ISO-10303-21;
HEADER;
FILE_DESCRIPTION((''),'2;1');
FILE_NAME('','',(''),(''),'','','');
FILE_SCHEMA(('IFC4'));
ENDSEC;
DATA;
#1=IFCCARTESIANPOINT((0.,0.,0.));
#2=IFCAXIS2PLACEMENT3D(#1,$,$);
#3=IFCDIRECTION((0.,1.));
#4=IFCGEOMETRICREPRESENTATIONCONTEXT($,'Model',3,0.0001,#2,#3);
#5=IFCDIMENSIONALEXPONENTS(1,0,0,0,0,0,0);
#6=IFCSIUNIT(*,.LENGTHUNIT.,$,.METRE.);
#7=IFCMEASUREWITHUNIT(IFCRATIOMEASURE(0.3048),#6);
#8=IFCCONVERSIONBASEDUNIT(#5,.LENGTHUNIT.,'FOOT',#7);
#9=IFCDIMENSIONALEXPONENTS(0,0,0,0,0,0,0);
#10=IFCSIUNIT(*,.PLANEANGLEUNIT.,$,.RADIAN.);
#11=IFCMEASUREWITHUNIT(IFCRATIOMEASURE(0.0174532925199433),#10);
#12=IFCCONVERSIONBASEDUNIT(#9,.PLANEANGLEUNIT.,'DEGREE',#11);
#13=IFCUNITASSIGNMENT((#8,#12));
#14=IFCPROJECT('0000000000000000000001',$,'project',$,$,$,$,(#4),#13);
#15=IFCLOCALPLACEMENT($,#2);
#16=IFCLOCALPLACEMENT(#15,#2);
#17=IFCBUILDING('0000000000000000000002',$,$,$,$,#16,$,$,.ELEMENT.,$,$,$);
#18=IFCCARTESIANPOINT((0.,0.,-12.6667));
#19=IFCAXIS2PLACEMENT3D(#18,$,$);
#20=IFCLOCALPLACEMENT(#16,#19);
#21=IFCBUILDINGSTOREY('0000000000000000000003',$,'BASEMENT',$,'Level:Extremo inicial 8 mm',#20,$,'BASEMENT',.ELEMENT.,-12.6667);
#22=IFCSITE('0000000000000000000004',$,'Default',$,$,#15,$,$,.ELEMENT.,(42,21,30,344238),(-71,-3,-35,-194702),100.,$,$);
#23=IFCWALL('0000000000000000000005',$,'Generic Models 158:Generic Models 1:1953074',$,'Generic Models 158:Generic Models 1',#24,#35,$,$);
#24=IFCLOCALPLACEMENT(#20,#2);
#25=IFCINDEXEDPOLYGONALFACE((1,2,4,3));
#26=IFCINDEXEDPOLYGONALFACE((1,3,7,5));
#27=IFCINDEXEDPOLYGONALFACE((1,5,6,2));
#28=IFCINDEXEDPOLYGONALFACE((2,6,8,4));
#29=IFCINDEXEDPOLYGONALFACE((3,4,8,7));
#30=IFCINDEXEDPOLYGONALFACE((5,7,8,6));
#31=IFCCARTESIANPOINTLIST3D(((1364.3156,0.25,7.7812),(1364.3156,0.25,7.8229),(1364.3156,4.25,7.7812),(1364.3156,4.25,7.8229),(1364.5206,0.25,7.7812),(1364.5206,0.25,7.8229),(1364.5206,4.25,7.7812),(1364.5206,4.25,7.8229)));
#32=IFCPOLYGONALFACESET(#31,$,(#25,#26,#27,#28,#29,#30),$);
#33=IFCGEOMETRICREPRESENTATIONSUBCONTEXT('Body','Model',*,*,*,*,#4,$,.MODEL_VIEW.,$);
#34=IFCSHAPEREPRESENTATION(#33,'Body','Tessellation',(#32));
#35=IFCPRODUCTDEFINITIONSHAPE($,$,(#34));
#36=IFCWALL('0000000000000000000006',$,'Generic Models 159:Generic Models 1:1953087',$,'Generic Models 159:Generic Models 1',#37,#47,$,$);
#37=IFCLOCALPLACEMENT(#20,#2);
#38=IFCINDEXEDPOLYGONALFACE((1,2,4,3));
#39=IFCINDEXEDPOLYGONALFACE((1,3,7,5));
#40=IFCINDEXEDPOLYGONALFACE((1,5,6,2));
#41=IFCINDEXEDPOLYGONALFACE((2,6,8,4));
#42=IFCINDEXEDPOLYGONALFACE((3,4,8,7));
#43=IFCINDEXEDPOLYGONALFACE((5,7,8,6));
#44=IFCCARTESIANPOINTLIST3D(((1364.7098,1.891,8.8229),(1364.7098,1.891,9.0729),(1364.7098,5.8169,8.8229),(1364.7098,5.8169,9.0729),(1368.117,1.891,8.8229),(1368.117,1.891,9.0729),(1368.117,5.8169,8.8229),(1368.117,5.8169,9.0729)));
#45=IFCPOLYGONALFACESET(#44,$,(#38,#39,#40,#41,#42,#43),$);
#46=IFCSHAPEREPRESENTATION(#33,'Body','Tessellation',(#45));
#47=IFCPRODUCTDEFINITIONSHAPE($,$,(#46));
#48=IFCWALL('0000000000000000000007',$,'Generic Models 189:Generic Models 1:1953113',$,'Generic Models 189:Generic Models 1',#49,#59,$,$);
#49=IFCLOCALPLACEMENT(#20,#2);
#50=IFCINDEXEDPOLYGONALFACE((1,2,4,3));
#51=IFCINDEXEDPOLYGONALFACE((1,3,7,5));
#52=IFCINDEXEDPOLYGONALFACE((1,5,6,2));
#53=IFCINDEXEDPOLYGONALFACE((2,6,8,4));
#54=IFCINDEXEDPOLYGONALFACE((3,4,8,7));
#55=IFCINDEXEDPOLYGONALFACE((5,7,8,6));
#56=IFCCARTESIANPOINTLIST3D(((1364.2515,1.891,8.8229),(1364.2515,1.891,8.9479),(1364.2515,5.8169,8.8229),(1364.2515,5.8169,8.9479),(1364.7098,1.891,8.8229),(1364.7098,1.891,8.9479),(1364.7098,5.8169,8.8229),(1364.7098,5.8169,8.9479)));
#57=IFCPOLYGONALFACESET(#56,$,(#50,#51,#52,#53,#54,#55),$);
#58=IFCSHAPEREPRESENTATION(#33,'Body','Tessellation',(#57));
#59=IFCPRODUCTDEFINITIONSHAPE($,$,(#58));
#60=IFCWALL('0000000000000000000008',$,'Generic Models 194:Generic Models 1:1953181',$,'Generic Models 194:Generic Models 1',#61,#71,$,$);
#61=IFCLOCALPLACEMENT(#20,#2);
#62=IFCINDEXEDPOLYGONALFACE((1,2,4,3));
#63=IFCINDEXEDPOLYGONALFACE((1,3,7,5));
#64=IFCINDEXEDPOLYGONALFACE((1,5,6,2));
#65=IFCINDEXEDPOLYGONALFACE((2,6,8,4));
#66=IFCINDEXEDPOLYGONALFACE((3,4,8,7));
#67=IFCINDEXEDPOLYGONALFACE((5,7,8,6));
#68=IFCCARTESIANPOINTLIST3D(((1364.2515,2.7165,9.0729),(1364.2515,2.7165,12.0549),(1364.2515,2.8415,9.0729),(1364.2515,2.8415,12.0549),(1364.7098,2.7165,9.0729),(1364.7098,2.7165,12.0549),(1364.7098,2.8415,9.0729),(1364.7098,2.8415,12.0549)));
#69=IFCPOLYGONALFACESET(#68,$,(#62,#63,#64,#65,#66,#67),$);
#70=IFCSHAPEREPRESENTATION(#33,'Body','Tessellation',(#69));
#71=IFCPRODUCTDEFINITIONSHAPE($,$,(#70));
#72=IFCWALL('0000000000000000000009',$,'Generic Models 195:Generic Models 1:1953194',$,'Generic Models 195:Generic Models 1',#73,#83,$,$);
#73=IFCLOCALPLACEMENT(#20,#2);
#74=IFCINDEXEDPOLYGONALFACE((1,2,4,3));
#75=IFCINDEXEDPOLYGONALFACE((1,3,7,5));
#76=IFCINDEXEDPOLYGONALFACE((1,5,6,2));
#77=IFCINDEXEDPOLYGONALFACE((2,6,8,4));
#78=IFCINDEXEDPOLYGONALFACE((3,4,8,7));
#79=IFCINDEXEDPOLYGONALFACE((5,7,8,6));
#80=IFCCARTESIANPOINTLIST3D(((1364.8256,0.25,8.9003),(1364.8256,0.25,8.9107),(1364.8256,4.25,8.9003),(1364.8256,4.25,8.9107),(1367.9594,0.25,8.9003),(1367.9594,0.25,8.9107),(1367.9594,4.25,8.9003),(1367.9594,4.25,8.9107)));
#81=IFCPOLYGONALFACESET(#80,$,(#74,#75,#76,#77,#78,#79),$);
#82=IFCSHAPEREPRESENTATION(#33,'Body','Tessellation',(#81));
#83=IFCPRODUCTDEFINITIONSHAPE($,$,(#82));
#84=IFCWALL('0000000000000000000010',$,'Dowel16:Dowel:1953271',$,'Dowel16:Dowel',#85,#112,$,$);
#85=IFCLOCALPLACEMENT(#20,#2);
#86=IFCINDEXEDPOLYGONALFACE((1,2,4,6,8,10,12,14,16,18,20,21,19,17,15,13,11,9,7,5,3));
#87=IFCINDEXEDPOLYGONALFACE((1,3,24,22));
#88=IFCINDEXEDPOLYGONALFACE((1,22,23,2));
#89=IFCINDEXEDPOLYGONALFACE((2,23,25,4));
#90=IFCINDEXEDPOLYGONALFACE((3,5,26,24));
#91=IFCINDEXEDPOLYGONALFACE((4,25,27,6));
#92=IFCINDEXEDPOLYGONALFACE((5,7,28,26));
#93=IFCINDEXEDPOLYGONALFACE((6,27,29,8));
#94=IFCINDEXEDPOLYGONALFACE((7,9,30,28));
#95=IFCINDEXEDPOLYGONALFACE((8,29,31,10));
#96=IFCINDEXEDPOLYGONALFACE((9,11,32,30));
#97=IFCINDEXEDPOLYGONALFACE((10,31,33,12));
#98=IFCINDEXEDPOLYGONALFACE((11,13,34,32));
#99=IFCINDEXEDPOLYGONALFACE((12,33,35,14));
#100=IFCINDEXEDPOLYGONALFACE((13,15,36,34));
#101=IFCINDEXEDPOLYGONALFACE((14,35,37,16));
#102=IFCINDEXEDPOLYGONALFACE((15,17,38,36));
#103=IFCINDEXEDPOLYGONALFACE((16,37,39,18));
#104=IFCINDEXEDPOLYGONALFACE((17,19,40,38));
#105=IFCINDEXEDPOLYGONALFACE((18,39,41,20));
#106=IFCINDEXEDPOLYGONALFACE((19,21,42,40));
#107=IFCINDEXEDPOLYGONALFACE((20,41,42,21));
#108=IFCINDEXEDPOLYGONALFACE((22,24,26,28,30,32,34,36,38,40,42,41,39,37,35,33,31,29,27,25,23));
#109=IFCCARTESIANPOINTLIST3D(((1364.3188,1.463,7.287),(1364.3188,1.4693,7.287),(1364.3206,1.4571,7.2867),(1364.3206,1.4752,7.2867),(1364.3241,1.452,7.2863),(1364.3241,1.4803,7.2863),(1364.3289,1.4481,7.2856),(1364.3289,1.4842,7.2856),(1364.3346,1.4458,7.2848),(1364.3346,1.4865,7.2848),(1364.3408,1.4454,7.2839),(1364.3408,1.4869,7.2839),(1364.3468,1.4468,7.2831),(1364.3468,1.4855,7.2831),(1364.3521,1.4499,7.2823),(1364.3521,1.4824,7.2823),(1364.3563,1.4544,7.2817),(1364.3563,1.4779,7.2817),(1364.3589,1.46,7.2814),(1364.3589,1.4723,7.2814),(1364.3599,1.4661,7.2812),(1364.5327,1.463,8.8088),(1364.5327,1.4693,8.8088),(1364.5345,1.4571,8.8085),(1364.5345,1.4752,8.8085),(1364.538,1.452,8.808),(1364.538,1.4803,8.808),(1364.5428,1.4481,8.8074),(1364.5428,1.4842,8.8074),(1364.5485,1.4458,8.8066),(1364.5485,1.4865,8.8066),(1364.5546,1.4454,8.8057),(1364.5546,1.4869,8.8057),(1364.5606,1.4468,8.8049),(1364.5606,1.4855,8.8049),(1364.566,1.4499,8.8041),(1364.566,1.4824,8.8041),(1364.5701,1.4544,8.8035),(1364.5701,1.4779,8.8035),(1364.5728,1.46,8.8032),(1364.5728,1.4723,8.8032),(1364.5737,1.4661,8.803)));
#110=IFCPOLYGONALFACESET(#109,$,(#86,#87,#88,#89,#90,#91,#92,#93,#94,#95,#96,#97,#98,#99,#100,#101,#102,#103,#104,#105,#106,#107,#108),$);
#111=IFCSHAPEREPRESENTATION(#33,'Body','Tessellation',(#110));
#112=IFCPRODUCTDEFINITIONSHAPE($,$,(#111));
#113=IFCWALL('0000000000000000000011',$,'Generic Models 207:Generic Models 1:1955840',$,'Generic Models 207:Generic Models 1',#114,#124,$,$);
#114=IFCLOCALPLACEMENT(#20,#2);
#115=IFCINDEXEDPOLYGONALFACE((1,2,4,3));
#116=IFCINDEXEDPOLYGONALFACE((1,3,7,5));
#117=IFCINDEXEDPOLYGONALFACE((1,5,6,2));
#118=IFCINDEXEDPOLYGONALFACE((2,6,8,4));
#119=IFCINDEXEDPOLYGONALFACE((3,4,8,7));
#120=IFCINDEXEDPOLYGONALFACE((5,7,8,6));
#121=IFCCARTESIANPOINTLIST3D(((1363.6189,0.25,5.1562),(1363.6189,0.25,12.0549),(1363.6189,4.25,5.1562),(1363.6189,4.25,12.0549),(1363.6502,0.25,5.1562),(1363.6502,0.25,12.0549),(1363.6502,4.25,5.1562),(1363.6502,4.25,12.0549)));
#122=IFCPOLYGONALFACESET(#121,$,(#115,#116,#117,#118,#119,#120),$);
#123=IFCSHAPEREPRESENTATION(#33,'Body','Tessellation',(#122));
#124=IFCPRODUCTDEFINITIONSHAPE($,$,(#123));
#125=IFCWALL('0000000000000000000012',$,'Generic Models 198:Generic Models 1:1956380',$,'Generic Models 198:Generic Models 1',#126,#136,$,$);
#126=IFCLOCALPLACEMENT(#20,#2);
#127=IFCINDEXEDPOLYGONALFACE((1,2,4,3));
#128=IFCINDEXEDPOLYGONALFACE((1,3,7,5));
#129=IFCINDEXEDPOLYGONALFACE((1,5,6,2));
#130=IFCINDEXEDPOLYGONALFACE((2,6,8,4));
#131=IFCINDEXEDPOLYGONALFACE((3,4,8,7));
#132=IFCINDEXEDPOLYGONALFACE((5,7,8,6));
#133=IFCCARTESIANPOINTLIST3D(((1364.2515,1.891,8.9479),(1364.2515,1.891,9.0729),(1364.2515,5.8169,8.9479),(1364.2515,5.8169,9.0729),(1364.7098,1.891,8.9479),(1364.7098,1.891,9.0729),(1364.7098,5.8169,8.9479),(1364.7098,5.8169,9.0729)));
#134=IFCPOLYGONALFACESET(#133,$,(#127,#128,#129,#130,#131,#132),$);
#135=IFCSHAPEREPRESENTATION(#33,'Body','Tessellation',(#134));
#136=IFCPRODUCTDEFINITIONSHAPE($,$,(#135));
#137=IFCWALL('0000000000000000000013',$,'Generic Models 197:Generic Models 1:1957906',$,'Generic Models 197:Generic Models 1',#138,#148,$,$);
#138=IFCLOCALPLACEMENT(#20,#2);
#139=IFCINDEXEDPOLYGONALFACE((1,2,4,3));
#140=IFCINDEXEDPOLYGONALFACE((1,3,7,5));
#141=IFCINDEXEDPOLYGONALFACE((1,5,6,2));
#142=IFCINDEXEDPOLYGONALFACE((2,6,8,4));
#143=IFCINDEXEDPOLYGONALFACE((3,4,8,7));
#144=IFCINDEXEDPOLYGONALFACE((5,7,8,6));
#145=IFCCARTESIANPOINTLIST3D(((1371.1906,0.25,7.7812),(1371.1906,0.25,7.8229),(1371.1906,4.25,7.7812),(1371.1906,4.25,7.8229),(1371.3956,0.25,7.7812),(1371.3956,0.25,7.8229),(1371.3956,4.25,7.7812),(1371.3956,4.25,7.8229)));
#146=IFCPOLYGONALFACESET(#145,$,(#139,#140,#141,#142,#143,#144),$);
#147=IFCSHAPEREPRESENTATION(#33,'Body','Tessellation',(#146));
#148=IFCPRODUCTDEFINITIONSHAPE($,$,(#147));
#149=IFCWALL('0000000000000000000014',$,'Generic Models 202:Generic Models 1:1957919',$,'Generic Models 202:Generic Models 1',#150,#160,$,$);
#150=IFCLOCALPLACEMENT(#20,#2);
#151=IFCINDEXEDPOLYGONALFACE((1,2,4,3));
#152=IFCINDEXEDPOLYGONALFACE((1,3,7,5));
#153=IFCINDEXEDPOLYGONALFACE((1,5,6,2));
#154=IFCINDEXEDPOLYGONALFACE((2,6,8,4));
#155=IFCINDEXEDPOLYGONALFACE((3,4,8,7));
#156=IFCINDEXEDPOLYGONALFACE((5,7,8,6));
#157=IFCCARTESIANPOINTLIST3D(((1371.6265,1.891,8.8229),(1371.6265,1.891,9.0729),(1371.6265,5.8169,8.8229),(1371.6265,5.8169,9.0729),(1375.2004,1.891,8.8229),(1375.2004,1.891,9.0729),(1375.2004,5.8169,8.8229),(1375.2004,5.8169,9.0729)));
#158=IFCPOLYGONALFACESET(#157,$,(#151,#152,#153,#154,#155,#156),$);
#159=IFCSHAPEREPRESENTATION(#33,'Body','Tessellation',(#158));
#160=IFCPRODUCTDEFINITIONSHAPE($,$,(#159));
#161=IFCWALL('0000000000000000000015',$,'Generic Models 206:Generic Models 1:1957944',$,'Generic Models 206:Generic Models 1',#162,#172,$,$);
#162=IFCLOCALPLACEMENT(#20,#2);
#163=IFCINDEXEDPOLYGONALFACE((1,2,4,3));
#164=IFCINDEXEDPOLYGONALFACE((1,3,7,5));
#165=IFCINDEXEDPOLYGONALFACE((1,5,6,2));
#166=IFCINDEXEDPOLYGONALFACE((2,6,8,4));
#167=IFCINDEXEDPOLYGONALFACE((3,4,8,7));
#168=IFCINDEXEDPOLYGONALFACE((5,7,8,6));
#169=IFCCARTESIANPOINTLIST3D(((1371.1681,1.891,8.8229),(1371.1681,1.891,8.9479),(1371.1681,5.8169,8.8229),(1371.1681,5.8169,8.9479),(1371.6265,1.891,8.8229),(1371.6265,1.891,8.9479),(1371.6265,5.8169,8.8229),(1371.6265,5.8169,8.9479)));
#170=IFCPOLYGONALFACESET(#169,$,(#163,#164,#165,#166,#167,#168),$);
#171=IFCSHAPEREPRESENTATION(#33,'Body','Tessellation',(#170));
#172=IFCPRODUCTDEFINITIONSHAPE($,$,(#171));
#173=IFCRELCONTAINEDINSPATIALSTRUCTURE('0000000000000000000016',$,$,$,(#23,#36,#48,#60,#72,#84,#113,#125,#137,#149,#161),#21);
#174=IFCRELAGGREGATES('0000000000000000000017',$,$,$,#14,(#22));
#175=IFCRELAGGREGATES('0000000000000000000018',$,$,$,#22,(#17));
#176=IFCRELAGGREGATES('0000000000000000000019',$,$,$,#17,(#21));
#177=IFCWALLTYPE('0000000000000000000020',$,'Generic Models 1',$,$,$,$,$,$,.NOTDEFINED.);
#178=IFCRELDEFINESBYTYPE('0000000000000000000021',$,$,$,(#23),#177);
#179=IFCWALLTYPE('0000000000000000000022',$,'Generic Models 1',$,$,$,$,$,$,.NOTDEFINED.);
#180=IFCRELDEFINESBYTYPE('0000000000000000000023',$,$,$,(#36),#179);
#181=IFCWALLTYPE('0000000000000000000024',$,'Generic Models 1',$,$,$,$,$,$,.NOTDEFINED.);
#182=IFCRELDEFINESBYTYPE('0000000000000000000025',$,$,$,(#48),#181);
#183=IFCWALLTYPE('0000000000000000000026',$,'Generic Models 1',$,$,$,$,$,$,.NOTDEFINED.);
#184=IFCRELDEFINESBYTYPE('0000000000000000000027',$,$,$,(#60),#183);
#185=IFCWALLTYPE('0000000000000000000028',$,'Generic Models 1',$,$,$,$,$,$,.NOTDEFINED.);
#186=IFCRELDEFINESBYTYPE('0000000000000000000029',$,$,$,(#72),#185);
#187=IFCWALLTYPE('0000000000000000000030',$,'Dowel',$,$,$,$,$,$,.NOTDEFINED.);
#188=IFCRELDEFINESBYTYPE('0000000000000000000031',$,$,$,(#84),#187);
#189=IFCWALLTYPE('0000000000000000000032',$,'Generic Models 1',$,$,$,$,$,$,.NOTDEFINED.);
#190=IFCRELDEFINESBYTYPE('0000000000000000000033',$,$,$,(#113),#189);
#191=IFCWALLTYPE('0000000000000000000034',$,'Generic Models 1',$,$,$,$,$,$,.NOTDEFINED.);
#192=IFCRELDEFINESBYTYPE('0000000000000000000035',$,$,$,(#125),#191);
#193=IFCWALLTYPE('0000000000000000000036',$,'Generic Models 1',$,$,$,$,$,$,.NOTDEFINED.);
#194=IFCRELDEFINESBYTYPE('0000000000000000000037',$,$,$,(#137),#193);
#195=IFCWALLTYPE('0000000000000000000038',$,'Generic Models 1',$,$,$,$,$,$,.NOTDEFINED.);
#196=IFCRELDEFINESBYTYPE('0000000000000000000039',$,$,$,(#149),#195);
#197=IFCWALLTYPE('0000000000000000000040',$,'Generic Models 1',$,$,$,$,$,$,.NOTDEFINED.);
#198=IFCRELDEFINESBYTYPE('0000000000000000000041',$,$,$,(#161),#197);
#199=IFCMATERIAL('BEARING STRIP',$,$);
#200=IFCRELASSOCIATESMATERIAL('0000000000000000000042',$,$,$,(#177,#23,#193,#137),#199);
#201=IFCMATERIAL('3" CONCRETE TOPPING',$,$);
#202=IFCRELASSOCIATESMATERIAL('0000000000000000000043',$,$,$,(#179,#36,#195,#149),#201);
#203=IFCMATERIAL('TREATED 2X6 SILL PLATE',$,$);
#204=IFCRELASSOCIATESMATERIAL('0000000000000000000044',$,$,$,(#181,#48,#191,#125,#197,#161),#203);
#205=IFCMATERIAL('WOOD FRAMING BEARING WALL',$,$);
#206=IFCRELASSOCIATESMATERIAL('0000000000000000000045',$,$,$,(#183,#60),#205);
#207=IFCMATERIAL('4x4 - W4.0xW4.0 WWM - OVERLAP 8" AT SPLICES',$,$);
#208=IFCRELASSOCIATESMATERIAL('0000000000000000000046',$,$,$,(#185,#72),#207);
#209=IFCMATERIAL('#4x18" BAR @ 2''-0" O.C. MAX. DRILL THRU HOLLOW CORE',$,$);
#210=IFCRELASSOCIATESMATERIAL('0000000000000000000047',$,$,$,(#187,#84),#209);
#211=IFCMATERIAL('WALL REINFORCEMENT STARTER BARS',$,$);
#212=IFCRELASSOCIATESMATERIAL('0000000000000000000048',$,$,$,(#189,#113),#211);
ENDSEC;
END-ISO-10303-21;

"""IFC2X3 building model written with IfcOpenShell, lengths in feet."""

from ifc_helpers import new_model, entity, si_unit, converted_unit, direction, frame, frame_2d, origin, origin_2d_with_axis, place, context, subcontext, project, spatial, rectangle, circle, extrude, material, type_object, element, save


model = new_model("IFC2X3")

# Units and contexts
model_context = context("Model", 3, precision=0.0001, world=origin(), true_north=direction((0.0, 1.0)))
body_context = subcontext(model_context, "Body", "Model", "MODEL_VIEW")
ifc_project = project(units=[converted_unit("LENGTHUNIT", "FOOT", entity("IfcRatioMeasure", 0.3048), si_unit("LENGTHUNIT", "METRE"), dimensions=[1, 0, 0, 0, 0, 0, 0]), converted_unit("PLANEANGLEUNIT", "DEGREE", entity("IfcRatioMeasure", 0.0174532925199433), si_unit("PLANEANGLEUNIT", "RADIAN"), dimensions=[0, 0, 0, 0, 0, 0, 0])], contexts=[model_context])

# Site, building, storey
site_placement = place(None, origin())
site = spatial("IfcSite", under=ifc_project, at=site_placement, Name="Default", CompositionType="ELEMENT", RefLatitude=(42, 21, 30, 344238), RefLongitude=(-71, -3, -35, -194702), RefElevation=100.0)
building_placement = place(site_placement, origin())
building = spatial("IfcBuilding", under=site, at=building_placement, CompositionType="ELEMENT")
storey_placement = place(building_placement, frame((0.0, 0.0, -12.6667)))
storey = spatial("IfcBuildingStorey", under=building, at=storey_placement, Name="BASEMENT", ObjectType="Level:Extremo inicial 8 mm", LongName="BASEMENT", CompositionType="ELEMENT", Elevation=-12.6667)

# Walls
ifc_material_1 = material(Name="BEARING STRIP")
wall_type_1 = type_object("IfcWallType", Name="Generic Models 1", PredefinedType="NOTDEFINED", material=ifc_material_1)
wall_1_placement = place(storey_placement, frame((1364.3156, 0.25, 7.7812), z_axis=(0.0, 0.0, 1.0), x_axis=(0.0, 1.0, 0.0)))
element("IfcWall", 1, at=wall_1_placement, inside=storey, type_object=wall_type_1, material=ifc_material_1, Name="Generic Models 158:Generic Models 1:1953074", ObjectType="Generic Models 158:Generic Models 1", context=body_context, shape_type="SweptSolid", body=[
    extrude(rectangle(XDim=4.0, YDim=0.205, at=frame_2d((0.0, 0.0), x_axis=(1.0, 0.0))), frame((2.0, -0.1025, 0.0)), (0.0, 0.0, 1.0), 0.0417),
])
ifc_material_2 = material(Name="3\" CONCRETE TOPPING")
wall_type_2 = type_object("IfcWallType", Name="Generic Models 1", PredefinedType="NOTDEFINED", material=ifc_material_2)
wall_2_placement = place(storey_placement, frame((1364.7098, 1.891, 8.8229), z_axis=(0.0, 0.0, 1.0), x_axis=(0.0, 1.0, 0.0)))
element("IfcWall", 2, at=wall_2_placement, inside=storey, type_object=wall_type_2, material=ifc_material_2, Name="Generic Models 159:Generic Models 1:1953087", ObjectType="Generic Models 159:Generic Models 1", context=body_context, shape_type="SweptSolid", body=[
    extrude(rectangle(XDim=3.9258, YDim=3.4072, at=frame_2d((0.0, 0.0), x_axis=(1.0, 0.0))), frame((1.9629, -1.7036, 0.0)), (0.0, 0.0, 1.0), 0.25),
])
ifc_material_3 = material(Name="TREATED 2X6 SILL PLATE")
wall_type_3 = type_object("IfcWallType", Name="Generic Models 1", PredefinedType="NOTDEFINED", material=ifc_material_3)
wall_3_placement = place(storey_placement, frame((1364.2515, 1.891, 8.8229), z_axis=(0.0, 0.0, 1.0), x_axis=(0.0, 1.0, 0.0)))
element("IfcWall", 3, at=wall_3_placement, inside=storey, type_object=wall_type_3, material=ifc_material_3, Name="Generic Models 189:Generic Models 1:1953113", ObjectType="Generic Models 189:Generic Models 1", context=body_context, shape_type="SweptSolid", body=[
    extrude(rectangle(XDim=3.9258, YDim=0.4583, at=frame_2d((0.0, 0.0), x_axis=(1.0, 0.0))), frame((1.9629, -0.2292, 0.0)), (0.0, 0.0, 1.0), 0.125),
])
ifc_material_4 = material(Name="WOOD FRAMING BEARING WALL")
wall_type_4 = type_object("IfcWallType", Name="Generic Models 1", PredefinedType="NOTDEFINED", material=ifc_material_4)
wall_4_placement = place(storey_placement, frame((1364.2515, 2.7165, 9.0729)))
element("IfcWall", 4, at=wall_4_placement, inside=storey, type_object=wall_type_4, material=ifc_material_4, Name="Generic Models 194:Generic Models 1:1953181", ObjectType="Generic Models 194:Generic Models 1", context=body_context, shape_type="SweptSolid", body=[
    extrude(rectangle(XDim=0.125, YDim=0.4583, at=frame_2d((0.0, 0.0), x_axis=(1.0, 0.0))), frame((0.2292, 0.0625, 0.0), z_axis=(0.0, 0.0, 1.0), x_axis=(0.0, 1.0, 0.0)), (0.0, 0.0, 1.0), 2.982),
])
ifc_material_5 = material(Name="4x4 - W4.0xW4.0 WWM - OVERLAP 8\" AT SPLICES")
wall_type_5 = type_object("IfcWallType", Name="Generic Models 1", PredefinedType="NOTDEFINED", material=ifc_material_5)
wall_5_placement = place(storey_placement, frame((1364.8256, 0.25, 8.9003), z_axis=(0.0, 0.0, 1.0), x_axis=(0.0, 1.0, 0.0)))
element("IfcWall", 5, at=wall_5_placement, inside=storey, type_object=wall_type_5, material=ifc_material_5, Name="Generic Models 195:Generic Models 1:1953194", ObjectType="Generic Models 195:Generic Models 1", context=body_context, shape_type="SweptSolid", body=[
    extrude(rectangle(XDim=4.0, YDim=3.1338, at=frame_2d((0.0, 0.0), x_axis=(1.0, 0.0))), frame((2.0, -1.5669, 0.0)), (0.0, 0.0, 1.0), 0.0104),
])
ifc_material_6 = material(Name="#4x18\" BAR @ 2'-0\" O.C. MAX. DRILL THRU HOLLOW CORE")
wall_type_6 = type_object("IfcWallType", Name="Dowel", PredefinedType="NOTDEFINED", material=ifc_material_6)
wall_6_placement = place(storey_placement, frame((1364.3186, 1.4453, 7.2812)))
element("IfcWall", 6, at=wall_6_placement, inside=storey, type_object=wall_type_6, material=ifc_material_6, Name="Dowel16:Dowel:1953271", ObjectType="Dowel16:Dowel", context=body_context, shape_type="SweptSolid", body=[
    extrude(circle(Radius=0.0208, at=origin_2d_with_axis()), frame((0.0206, 0.0208, 0.0029), z_axis=(0.139173, 0.0, 0.990268), x_axis=(0.990268, 0.0, -0.139173)), (0.0, 0.0, 1.0), 1.5368),
])
ifc_material_7 = material(Name="WALL REINFORCEMENT STARTER BARS")
wall_type_7 = type_object("IfcWallType", Name="Generic Models 1", PredefinedType="NOTDEFINED", material=ifc_material_7)
wall_7_placement = place(storey_placement, frame((1363.6189, 0.25, 5.1562), z_axis=(0.0, 0.0, 1.0), x_axis=(0.0, 1.0, 0.0)))
element("IfcWall", 7, at=wall_7_placement, inside=storey, type_object=wall_type_7, material=ifc_material_7, Name="Generic Models 207:Generic Models 1:1955840", ObjectType="Generic Models 207:Generic Models 1", context=body_context, shape_type="SweptSolid", body=[
    extrude(rectangle(XDim=4.0, YDim=0.0312, at=frame_2d((0.0, 0.0), x_axis=(1.0, 0.0))), frame((2.0, -0.0156, 0.0)), (0.0, 0.0, 1.0), 6.8986),
])
wall_type_8 = type_object("IfcWallType", Name="Generic Models 1", PredefinedType="NOTDEFINED", material=ifc_material_3)
wall_8_placement = place(storey_placement, frame((1364.2515, 1.891, 8.9479), z_axis=(0.0, 0.0, 1.0), x_axis=(0.0, 1.0, 0.0)))
element("IfcWall", 8, at=wall_8_placement, inside=storey, type_object=wall_type_8, material=ifc_material_3, Name="Generic Models 198:Generic Models 1:1956380", ObjectType="Generic Models 198:Generic Models 1", context=body_context, shape_type="SweptSolid", body=[
    extrude(rectangle(XDim=3.9258, YDim=0.4583, at=frame_2d((0.0, 0.0), x_axis=(1.0, 0.0))), frame((1.9629, -0.2292, 0.0)), (0.0, 0.0, 1.0), 0.125),
])
wall_type_9 = type_object("IfcWallType", Name="Generic Models 1", PredefinedType="NOTDEFINED", material=ifc_material_1)
wall_9_placement = place(storey_placement, frame((1371.1906, 0.25, 7.7812), z_axis=(0.0, 0.0, 1.0), x_axis=(0.0, 1.0, 0.0)))
element("IfcWall", 9, at=wall_9_placement, inside=storey, type_object=wall_type_9, material=ifc_material_1, Name="Generic Models 197:Generic Models 1:1957906", ObjectType="Generic Models 197:Generic Models 1", context=body_context, shape_type="SweptSolid", body=[
    extrude(rectangle(XDim=4.0, YDim=0.205, at=frame_2d((0.0, 0.0), x_axis=(1.0, 0.0))), frame((2.0, -0.1025, 0.0)), (0.0, 0.0, 1.0), 0.0417),
])
wall_type_10 = type_object("IfcWallType", Name="Generic Models 1", PredefinedType="NOTDEFINED", material=ifc_material_2)
wall_10_placement = place(storey_placement, frame((1371.6265, 1.891, 8.8229), z_axis=(0.0, 0.0, 1.0), x_axis=(0.0, 1.0, 0.0)))
element("IfcWall", 10, at=wall_10_placement, inside=storey, type_object=wall_type_10, material=ifc_material_2, Name="Generic Models 202:Generic Models 1:1957919", ObjectType="Generic Models 202:Generic Models 1", context=body_context, shape_type="SweptSolid", body=[
    extrude(rectangle(XDim=3.9258, YDim=3.5739, at=frame_2d((0.0, 0.0), x_axis=(1.0, 0.0))), frame((1.9629, -1.7869, 0.0)), (0.0, 0.0, 1.0), 0.25),
])
wall_type_11 = type_object("IfcWallType", Name="Generic Models 1", PredefinedType="NOTDEFINED", material=ifc_material_3)
wall_11_placement = place(storey_placement, frame((1371.1681, 1.891, 8.8229), z_axis=(0.0, 0.0, 1.0), x_axis=(0.0, 1.0, 0.0)))
element("IfcWall", 11, at=wall_11_placement, inside=storey, type_object=wall_type_11, material=ifc_material_3, Name="Generic Models 206:Generic Models 1:1957944", ObjectType="Generic Models 206:Generic Models 1", context=body_context, shape_type="SweptSolid", body=[
    extrude(rectangle(XDim=3.9258, YDim=0.4583, at=frame_2d((0.0, 0.0), x_axis=(1.0, 0.0))), frame((1.9629, -0.2292, 0.0)), (0.0, 0.0, 1.0), 0.125),
])

save(model, "model.ifc")
